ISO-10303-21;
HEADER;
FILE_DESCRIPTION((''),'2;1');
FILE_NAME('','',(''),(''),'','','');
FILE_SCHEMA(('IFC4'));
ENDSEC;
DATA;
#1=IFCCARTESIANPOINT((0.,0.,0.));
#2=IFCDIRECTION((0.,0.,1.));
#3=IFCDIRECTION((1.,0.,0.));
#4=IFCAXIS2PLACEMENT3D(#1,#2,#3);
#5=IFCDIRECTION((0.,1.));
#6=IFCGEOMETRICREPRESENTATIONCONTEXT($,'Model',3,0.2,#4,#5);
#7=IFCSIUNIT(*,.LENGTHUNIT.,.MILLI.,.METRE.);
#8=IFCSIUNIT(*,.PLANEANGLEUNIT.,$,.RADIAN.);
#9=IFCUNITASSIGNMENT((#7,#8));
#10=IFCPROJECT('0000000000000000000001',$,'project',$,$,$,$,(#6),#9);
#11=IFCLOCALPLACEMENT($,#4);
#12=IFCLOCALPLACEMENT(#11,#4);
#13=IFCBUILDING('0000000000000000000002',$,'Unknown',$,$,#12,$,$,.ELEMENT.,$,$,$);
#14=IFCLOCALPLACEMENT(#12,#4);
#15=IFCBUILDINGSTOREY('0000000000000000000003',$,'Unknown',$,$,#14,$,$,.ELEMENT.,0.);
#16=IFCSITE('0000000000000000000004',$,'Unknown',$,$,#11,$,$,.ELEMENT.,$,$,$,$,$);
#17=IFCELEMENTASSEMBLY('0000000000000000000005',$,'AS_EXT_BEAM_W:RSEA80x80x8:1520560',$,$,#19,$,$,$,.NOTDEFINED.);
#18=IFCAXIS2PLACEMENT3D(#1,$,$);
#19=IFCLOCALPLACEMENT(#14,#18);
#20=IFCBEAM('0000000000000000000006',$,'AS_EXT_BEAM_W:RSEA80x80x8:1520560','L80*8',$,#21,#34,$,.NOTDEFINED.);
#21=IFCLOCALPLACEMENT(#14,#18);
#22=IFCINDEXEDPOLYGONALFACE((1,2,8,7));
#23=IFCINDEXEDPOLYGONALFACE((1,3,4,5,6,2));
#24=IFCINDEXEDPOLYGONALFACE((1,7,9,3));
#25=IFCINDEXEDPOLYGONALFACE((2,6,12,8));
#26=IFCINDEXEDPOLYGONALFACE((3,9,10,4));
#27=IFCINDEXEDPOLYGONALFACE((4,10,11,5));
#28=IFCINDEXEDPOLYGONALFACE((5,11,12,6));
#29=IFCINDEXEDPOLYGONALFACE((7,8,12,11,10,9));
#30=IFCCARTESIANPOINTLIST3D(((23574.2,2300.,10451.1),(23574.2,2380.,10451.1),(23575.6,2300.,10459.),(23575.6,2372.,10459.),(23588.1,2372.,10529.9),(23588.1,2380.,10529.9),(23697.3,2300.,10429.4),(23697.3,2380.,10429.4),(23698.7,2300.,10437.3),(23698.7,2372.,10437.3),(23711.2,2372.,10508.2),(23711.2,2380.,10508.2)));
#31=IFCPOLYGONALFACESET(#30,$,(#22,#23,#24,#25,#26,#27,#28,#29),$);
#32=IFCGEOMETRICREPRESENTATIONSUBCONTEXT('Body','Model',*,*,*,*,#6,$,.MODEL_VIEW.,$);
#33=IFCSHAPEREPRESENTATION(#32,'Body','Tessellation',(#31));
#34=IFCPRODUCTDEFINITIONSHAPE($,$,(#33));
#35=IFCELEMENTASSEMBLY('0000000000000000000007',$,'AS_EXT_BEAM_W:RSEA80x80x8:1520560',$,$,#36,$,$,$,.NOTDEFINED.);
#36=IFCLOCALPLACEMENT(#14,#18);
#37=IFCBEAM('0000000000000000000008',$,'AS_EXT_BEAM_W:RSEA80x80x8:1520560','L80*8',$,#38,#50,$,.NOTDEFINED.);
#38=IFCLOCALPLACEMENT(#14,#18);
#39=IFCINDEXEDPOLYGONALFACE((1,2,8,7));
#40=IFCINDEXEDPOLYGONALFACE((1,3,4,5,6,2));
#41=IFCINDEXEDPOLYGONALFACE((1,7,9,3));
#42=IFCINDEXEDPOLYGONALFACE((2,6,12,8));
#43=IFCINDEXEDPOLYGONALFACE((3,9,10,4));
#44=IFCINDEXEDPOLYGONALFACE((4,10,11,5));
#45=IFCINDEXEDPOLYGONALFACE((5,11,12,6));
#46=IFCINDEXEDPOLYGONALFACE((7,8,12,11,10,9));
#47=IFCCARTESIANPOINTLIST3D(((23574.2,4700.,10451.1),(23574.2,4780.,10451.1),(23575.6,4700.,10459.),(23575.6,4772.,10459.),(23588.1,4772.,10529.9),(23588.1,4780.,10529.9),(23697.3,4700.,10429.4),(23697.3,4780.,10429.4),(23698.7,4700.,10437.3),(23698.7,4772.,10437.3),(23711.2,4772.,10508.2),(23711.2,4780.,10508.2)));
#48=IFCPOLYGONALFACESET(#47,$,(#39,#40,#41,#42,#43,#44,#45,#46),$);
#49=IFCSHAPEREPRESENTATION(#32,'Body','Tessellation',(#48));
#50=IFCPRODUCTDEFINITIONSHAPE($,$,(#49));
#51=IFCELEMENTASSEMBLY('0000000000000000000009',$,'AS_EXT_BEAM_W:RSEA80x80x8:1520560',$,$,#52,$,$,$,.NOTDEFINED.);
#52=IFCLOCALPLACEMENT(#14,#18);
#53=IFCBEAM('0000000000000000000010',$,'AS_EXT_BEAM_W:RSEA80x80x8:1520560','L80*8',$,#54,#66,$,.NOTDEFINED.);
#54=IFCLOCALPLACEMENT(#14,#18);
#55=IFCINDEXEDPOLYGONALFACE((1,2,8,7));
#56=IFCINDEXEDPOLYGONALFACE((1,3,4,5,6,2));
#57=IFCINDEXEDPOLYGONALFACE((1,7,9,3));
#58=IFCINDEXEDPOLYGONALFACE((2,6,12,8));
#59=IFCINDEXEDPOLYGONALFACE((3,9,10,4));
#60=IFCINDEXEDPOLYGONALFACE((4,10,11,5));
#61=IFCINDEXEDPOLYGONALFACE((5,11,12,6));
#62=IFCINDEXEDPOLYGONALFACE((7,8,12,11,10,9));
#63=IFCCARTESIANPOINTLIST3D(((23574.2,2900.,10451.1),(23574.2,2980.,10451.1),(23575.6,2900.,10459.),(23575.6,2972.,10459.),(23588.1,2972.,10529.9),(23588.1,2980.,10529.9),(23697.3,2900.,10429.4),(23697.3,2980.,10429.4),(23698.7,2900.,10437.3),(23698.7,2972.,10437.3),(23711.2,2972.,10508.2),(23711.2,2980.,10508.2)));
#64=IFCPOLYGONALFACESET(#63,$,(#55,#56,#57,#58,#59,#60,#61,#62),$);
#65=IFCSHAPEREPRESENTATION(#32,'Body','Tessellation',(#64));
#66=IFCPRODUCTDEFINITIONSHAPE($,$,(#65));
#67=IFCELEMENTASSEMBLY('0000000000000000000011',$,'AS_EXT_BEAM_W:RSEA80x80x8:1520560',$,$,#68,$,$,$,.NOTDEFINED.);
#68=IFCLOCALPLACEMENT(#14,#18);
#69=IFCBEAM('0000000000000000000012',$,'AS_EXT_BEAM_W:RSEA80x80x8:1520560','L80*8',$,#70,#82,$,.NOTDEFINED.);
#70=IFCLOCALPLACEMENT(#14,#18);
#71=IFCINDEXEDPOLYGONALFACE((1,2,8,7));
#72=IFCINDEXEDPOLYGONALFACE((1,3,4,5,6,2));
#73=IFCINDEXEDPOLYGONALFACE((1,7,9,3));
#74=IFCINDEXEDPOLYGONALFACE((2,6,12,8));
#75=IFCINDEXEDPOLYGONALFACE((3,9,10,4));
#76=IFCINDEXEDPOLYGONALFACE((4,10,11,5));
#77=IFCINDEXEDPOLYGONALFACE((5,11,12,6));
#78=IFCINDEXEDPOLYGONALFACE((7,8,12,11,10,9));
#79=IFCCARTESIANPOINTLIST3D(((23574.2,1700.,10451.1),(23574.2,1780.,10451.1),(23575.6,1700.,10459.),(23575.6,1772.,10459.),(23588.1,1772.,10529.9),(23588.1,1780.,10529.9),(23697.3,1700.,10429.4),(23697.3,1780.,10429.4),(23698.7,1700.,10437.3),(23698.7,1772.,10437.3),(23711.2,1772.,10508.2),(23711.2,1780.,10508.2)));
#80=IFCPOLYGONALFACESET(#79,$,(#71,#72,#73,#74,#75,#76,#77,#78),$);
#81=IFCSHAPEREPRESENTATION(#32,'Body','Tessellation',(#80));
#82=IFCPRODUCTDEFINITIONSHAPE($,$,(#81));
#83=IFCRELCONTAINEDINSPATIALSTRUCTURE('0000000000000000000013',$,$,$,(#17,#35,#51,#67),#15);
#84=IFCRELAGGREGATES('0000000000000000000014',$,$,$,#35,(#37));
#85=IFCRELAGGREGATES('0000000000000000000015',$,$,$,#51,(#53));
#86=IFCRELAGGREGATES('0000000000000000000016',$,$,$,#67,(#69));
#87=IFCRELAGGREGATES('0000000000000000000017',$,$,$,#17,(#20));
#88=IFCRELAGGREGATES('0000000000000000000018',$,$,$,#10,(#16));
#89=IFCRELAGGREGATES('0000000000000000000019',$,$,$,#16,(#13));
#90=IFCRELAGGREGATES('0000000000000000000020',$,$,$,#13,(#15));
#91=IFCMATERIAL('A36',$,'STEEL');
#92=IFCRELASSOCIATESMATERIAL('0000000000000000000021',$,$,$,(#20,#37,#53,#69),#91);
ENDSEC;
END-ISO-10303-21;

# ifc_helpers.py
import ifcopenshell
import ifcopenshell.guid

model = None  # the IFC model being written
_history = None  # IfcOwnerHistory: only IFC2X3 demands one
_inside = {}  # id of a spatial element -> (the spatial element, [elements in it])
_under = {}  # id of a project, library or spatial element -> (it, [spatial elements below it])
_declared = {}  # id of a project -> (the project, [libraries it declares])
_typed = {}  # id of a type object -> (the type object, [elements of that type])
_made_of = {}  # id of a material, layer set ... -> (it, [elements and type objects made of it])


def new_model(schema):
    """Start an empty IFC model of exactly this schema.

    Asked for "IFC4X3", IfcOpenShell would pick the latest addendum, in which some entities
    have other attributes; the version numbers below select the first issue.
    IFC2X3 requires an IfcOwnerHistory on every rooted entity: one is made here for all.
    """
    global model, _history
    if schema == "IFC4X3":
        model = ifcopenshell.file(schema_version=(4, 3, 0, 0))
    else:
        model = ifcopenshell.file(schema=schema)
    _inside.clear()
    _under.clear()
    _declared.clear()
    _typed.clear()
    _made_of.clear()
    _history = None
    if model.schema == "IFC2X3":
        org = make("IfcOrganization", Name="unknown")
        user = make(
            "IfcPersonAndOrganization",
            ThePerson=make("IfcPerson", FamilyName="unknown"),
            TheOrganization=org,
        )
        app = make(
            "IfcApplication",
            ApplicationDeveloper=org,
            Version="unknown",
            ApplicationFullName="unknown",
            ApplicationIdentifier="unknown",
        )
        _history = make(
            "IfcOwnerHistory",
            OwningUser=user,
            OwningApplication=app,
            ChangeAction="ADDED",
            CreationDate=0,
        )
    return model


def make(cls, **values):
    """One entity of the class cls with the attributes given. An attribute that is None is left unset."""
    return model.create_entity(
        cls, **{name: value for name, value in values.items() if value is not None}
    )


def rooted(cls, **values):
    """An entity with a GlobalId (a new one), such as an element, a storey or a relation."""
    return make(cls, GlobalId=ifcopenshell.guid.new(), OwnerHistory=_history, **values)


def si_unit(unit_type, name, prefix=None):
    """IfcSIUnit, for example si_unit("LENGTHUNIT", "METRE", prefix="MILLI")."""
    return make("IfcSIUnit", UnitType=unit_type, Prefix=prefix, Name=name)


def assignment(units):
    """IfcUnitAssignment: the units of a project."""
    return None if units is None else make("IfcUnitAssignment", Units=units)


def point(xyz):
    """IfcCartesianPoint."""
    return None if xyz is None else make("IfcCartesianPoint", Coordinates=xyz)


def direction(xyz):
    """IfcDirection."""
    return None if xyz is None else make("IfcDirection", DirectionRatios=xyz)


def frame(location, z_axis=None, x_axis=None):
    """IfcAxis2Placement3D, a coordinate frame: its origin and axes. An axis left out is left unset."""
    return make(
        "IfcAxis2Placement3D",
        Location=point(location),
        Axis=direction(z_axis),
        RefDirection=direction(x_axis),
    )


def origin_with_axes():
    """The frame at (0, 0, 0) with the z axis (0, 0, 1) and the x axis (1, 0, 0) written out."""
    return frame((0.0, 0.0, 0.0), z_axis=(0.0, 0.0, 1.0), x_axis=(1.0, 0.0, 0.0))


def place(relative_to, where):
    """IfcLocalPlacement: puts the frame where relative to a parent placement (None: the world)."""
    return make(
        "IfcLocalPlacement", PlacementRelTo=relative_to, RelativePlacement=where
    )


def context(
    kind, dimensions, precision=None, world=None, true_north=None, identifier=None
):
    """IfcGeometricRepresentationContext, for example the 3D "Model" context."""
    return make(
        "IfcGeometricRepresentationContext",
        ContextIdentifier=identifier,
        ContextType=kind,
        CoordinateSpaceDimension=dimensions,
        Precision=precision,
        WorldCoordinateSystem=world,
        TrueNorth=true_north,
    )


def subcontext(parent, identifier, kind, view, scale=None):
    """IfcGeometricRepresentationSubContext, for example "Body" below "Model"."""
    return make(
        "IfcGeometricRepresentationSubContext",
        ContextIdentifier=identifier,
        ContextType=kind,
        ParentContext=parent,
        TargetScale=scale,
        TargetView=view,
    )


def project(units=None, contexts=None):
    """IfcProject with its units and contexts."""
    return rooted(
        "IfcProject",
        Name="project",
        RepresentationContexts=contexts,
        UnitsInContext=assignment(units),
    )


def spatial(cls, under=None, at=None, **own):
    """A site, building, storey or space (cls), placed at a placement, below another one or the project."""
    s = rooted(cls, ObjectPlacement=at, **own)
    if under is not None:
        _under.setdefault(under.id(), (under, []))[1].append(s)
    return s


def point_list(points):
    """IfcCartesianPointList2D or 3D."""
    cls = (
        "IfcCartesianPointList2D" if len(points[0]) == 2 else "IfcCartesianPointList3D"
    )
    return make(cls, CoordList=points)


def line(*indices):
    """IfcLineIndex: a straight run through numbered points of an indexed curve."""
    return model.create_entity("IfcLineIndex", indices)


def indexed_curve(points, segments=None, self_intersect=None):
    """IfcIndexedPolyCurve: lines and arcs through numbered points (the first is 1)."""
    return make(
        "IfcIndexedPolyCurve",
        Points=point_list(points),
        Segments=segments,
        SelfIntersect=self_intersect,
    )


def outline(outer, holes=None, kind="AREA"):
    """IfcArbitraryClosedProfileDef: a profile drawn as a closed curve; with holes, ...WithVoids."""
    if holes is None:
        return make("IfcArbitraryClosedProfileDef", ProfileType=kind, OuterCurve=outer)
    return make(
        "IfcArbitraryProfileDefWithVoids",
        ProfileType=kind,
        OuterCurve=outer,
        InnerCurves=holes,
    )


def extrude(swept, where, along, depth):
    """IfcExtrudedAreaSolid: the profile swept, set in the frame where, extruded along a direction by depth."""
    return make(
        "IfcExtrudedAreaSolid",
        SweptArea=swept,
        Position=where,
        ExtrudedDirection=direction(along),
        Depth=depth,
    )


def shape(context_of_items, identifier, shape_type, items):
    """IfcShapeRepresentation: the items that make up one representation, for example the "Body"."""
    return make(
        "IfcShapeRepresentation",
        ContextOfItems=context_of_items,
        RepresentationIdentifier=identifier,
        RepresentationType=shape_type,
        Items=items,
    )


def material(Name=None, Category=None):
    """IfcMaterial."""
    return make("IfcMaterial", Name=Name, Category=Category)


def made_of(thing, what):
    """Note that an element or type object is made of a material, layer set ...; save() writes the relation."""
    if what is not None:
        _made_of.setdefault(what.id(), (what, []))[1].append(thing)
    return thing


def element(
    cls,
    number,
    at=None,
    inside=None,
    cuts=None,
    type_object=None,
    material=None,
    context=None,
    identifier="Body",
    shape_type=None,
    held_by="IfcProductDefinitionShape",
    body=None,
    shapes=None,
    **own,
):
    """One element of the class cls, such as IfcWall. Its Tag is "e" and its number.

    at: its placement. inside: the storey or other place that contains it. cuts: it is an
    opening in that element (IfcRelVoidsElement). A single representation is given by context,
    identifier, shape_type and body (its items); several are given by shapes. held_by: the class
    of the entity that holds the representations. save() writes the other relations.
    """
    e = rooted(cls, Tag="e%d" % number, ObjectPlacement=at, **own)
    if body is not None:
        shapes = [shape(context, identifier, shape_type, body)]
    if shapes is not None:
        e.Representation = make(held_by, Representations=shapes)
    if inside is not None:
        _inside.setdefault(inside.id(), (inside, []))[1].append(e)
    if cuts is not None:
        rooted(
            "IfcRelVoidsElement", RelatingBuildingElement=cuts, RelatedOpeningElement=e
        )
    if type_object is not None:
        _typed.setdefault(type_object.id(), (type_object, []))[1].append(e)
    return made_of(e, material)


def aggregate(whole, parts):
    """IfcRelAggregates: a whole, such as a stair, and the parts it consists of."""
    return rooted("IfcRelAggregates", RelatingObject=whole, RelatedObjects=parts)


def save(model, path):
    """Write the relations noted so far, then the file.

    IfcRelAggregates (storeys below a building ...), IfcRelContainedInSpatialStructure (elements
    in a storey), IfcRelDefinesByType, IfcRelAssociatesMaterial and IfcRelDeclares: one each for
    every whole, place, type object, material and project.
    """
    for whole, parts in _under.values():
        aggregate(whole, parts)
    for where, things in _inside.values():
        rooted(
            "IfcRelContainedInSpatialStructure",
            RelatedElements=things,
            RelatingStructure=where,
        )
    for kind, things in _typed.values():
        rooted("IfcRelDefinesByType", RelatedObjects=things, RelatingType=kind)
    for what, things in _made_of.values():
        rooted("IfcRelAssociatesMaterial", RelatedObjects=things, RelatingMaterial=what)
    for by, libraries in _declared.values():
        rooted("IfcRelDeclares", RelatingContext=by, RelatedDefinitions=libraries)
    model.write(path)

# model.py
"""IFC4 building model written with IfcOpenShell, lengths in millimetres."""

from ifc_helpers import new_model, si_unit, direction, frame, origin_with_axes, place, context, subcontext, project, spatial, line, indexed_curve, outline, extrude, material, element, aggregate, save


model = new_model("IFC4")

# Units and contexts
model_context = context("Model", 3, precision=0.2, world=origin_with_axes(), true_north=direction((0.0, 1.0)))
body_context = subcontext(model_context, "Body", "Model", "MODEL_VIEW")
ifc_project = project(units=[si_unit("LENGTHUNIT", "METRE", prefix="MILLI"), si_unit("PLANEANGLEUNIT", "RADIAN")], contexts=[model_context])

# Site, building, storey
site_placement = place(None, origin_with_axes())
site = spatial("IfcSite", under=ifc_project, at=site_placement, Name="Unknown", CompositionType="ELEMENT")
building_placement = place(site_placement, origin_with_axes())
building = spatial("IfcBuilding", under=site, at=building_placement, Name="Unknown", CompositionType="ELEMENT")
storey_placement = place(building_placement, origin_with_axes())
storey = spatial("IfcBuildingStorey", under=building, at=storey_placement, Name="Unknown", CompositionType="ELEMENT", Elevation=0.0)

# Element assemblies, beams
ifc_material_1 = material(Name="A36", Category="STEEL")
assembly_1_placement = place(storey_placement, frame((23581.1, 2340.0, 10490.5), z_axis=(0.0, -1.0, 0.0), x_axis=(0.984808, 0.0, -0.173648)))
assembly_1 = element("IfcElementAssembly", 1, at=assembly_1_placement, inside=storey, Name="AS_EXT_BEAM_W:RSEA80x80x8:1520560", PredefinedType="NOTDEFINED")
beam_1_placement = place(assembly_1_placement, origin_with_axes())
beam_1 = element("IfcBeam", 2, at=beam_1_placement, material=ifc_material_1, Name="AS_EXT_BEAM_W:RSEA80x80x8:1520560", Description="L80*8", PredefinedType="NOTDEFINED", context=body_context, shape_type="SolidModel", body=[
    extrude(outline(indexed_curve([(-40.0, -40.0), (40.0, -40.0), (40.0, -32.0), (-32.0, -32.0), (-32.0, 40.0), (-40.0, 40.0)], segments=[line(1, 2, 3, 4, 5, 6, 1)])), frame((0.0, 0.0, 0.0), z_axis=(-1.0, 0.0, 0.0), x_axis=(0.0, 0.0, 1.0)), (0.0, 0.0, -1.0), 125.0),
])
assembly_2_placement = place(storey_placement, frame((23581.1, 4740.0, 10490.5), z_axis=(0.0, -1.0, 0.0), x_axis=(0.984808, 0.0, -0.173648)))
assembly_2 = element("IfcElementAssembly", 3, at=assembly_2_placement, inside=storey, Name="AS_EXT_BEAM_W:RSEA80x80x8:1520560", PredefinedType="NOTDEFINED")
beam_2_placement = place(assembly_2_placement, origin_with_axes())
beam_2 = element("IfcBeam", 4, at=beam_2_placement, material=ifc_material_1, Name="AS_EXT_BEAM_W:RSEA80x80x8:1520560", Description="L80*8", PredefinedType="NOTDEFINED", context=body_context, shape_type="SolidModel", body=[
    extrude(outline(indexed_curve([(-40.0, -40.0), (40.0, -40.0), (40.0, -32.0), (-32.0, -32.0), (-32.0, 40.0), (-40.0, 40.0)], segments=[line(1, 2, 3, 4, 5, 6, 1)])), frame((0.0, 0.0, 0.0), z_axis=(-1.0, 0.0, 0.0), x_axis=(0.0, 0.0, 1.0)), (0.0, 0.0, -1.0), 125.0),
])
aggregate(assembly_2, [beam_2])
assembly_3_placement = place(storey_placement, frame((23581.1, 2940.0, 10490.5), z_axis=(0.0, -1.0, 0.0), x_axis=(0.984808, 0.0, -0.173648)))
assembly_3 = element("IfcElementAssembly", 5, at=assembly_3_placement, inside=storey, Name="AS_EXT_BEAM_W:RSEA80x80x8:1520560", PredefinedType="NOTDEFINED")
beam_3_placement = place(assembly_3_placement, origin_with_axes())
beam_3 = element("IfcBeam", 6, at=beam_3_placement, material=ifc_material_1, Name="AS_EXT_BEAM_W:RSEA80x80x8:1520560", Description="L80*8", PredefinedType="NOTDEFINED", context=body_context, shape_type="SolidModel", body=[
    extrude(outline(indexed_curve([(-40.0, -40.0), (40.0, -40.0), (40.0, -32.0), (-32.0, -32.0), (-32.0, 40.0), (-40.0, 40.0)], segments=[line(1, 2, 3, 4, 5, 6, 1)])), frame((0.0, 0.0, 0.0), z_axis=(-1.0, 0.0, 0.0), x_axis=(0.0, 0.0, 1.0)), (0.0, 0.0, -1.0), 125.0),
])
aggregate(assembly_3, [beam_3])
assembly_4_placement = place(storey_placement, frame((23581.1, 1740.0, 10490.5), z_axis=(0.0, -1.0, 0.0), x_axis=(0.984808, 0.0, -0.173648)))
assembly_4 = element("IfcElementAssembly", 7, at=assembly_4_placement, inside=storey, Name="AS_EXT_BEAM_W:RSEA80x80x8:1520560", PredefinedType="NOTDEFINED")
beam_4_placement = place(assembly_4_placement, origin_with_axes())
beam_4 = element("IfcBeam", 8, at=beam_4_placement, material=ifc_material_1, Name="AS_EXT_BEAM_W:RSEA80x80x8:1520560", Description="L80*8", PredefinedType="NOTDEFINED", context=body_context, shape_type="SolidModel", body=[
    extrude(outline(indexed_curve([(-40.0, -40.0), (40.0, -40.0), (40.0, -32.0), (-32.0, -32.0), (-32.0, 40.0), (-40.0, 40.0)], segments=[line(1, 2, 3, 4, 5, 6, 1)])), frame((0.0, 0.0, 0.0), z_axis=(-1.0, 0.0, 0.0), x_axis=(0.0, 0.0, 1.0)), (0.0, 0.0, -1.0), 125.0),
])
aggregate(assembly_4, [beam_4])

aggregate(assembly_1, [beam_1])

save(model, "model.ifc")
